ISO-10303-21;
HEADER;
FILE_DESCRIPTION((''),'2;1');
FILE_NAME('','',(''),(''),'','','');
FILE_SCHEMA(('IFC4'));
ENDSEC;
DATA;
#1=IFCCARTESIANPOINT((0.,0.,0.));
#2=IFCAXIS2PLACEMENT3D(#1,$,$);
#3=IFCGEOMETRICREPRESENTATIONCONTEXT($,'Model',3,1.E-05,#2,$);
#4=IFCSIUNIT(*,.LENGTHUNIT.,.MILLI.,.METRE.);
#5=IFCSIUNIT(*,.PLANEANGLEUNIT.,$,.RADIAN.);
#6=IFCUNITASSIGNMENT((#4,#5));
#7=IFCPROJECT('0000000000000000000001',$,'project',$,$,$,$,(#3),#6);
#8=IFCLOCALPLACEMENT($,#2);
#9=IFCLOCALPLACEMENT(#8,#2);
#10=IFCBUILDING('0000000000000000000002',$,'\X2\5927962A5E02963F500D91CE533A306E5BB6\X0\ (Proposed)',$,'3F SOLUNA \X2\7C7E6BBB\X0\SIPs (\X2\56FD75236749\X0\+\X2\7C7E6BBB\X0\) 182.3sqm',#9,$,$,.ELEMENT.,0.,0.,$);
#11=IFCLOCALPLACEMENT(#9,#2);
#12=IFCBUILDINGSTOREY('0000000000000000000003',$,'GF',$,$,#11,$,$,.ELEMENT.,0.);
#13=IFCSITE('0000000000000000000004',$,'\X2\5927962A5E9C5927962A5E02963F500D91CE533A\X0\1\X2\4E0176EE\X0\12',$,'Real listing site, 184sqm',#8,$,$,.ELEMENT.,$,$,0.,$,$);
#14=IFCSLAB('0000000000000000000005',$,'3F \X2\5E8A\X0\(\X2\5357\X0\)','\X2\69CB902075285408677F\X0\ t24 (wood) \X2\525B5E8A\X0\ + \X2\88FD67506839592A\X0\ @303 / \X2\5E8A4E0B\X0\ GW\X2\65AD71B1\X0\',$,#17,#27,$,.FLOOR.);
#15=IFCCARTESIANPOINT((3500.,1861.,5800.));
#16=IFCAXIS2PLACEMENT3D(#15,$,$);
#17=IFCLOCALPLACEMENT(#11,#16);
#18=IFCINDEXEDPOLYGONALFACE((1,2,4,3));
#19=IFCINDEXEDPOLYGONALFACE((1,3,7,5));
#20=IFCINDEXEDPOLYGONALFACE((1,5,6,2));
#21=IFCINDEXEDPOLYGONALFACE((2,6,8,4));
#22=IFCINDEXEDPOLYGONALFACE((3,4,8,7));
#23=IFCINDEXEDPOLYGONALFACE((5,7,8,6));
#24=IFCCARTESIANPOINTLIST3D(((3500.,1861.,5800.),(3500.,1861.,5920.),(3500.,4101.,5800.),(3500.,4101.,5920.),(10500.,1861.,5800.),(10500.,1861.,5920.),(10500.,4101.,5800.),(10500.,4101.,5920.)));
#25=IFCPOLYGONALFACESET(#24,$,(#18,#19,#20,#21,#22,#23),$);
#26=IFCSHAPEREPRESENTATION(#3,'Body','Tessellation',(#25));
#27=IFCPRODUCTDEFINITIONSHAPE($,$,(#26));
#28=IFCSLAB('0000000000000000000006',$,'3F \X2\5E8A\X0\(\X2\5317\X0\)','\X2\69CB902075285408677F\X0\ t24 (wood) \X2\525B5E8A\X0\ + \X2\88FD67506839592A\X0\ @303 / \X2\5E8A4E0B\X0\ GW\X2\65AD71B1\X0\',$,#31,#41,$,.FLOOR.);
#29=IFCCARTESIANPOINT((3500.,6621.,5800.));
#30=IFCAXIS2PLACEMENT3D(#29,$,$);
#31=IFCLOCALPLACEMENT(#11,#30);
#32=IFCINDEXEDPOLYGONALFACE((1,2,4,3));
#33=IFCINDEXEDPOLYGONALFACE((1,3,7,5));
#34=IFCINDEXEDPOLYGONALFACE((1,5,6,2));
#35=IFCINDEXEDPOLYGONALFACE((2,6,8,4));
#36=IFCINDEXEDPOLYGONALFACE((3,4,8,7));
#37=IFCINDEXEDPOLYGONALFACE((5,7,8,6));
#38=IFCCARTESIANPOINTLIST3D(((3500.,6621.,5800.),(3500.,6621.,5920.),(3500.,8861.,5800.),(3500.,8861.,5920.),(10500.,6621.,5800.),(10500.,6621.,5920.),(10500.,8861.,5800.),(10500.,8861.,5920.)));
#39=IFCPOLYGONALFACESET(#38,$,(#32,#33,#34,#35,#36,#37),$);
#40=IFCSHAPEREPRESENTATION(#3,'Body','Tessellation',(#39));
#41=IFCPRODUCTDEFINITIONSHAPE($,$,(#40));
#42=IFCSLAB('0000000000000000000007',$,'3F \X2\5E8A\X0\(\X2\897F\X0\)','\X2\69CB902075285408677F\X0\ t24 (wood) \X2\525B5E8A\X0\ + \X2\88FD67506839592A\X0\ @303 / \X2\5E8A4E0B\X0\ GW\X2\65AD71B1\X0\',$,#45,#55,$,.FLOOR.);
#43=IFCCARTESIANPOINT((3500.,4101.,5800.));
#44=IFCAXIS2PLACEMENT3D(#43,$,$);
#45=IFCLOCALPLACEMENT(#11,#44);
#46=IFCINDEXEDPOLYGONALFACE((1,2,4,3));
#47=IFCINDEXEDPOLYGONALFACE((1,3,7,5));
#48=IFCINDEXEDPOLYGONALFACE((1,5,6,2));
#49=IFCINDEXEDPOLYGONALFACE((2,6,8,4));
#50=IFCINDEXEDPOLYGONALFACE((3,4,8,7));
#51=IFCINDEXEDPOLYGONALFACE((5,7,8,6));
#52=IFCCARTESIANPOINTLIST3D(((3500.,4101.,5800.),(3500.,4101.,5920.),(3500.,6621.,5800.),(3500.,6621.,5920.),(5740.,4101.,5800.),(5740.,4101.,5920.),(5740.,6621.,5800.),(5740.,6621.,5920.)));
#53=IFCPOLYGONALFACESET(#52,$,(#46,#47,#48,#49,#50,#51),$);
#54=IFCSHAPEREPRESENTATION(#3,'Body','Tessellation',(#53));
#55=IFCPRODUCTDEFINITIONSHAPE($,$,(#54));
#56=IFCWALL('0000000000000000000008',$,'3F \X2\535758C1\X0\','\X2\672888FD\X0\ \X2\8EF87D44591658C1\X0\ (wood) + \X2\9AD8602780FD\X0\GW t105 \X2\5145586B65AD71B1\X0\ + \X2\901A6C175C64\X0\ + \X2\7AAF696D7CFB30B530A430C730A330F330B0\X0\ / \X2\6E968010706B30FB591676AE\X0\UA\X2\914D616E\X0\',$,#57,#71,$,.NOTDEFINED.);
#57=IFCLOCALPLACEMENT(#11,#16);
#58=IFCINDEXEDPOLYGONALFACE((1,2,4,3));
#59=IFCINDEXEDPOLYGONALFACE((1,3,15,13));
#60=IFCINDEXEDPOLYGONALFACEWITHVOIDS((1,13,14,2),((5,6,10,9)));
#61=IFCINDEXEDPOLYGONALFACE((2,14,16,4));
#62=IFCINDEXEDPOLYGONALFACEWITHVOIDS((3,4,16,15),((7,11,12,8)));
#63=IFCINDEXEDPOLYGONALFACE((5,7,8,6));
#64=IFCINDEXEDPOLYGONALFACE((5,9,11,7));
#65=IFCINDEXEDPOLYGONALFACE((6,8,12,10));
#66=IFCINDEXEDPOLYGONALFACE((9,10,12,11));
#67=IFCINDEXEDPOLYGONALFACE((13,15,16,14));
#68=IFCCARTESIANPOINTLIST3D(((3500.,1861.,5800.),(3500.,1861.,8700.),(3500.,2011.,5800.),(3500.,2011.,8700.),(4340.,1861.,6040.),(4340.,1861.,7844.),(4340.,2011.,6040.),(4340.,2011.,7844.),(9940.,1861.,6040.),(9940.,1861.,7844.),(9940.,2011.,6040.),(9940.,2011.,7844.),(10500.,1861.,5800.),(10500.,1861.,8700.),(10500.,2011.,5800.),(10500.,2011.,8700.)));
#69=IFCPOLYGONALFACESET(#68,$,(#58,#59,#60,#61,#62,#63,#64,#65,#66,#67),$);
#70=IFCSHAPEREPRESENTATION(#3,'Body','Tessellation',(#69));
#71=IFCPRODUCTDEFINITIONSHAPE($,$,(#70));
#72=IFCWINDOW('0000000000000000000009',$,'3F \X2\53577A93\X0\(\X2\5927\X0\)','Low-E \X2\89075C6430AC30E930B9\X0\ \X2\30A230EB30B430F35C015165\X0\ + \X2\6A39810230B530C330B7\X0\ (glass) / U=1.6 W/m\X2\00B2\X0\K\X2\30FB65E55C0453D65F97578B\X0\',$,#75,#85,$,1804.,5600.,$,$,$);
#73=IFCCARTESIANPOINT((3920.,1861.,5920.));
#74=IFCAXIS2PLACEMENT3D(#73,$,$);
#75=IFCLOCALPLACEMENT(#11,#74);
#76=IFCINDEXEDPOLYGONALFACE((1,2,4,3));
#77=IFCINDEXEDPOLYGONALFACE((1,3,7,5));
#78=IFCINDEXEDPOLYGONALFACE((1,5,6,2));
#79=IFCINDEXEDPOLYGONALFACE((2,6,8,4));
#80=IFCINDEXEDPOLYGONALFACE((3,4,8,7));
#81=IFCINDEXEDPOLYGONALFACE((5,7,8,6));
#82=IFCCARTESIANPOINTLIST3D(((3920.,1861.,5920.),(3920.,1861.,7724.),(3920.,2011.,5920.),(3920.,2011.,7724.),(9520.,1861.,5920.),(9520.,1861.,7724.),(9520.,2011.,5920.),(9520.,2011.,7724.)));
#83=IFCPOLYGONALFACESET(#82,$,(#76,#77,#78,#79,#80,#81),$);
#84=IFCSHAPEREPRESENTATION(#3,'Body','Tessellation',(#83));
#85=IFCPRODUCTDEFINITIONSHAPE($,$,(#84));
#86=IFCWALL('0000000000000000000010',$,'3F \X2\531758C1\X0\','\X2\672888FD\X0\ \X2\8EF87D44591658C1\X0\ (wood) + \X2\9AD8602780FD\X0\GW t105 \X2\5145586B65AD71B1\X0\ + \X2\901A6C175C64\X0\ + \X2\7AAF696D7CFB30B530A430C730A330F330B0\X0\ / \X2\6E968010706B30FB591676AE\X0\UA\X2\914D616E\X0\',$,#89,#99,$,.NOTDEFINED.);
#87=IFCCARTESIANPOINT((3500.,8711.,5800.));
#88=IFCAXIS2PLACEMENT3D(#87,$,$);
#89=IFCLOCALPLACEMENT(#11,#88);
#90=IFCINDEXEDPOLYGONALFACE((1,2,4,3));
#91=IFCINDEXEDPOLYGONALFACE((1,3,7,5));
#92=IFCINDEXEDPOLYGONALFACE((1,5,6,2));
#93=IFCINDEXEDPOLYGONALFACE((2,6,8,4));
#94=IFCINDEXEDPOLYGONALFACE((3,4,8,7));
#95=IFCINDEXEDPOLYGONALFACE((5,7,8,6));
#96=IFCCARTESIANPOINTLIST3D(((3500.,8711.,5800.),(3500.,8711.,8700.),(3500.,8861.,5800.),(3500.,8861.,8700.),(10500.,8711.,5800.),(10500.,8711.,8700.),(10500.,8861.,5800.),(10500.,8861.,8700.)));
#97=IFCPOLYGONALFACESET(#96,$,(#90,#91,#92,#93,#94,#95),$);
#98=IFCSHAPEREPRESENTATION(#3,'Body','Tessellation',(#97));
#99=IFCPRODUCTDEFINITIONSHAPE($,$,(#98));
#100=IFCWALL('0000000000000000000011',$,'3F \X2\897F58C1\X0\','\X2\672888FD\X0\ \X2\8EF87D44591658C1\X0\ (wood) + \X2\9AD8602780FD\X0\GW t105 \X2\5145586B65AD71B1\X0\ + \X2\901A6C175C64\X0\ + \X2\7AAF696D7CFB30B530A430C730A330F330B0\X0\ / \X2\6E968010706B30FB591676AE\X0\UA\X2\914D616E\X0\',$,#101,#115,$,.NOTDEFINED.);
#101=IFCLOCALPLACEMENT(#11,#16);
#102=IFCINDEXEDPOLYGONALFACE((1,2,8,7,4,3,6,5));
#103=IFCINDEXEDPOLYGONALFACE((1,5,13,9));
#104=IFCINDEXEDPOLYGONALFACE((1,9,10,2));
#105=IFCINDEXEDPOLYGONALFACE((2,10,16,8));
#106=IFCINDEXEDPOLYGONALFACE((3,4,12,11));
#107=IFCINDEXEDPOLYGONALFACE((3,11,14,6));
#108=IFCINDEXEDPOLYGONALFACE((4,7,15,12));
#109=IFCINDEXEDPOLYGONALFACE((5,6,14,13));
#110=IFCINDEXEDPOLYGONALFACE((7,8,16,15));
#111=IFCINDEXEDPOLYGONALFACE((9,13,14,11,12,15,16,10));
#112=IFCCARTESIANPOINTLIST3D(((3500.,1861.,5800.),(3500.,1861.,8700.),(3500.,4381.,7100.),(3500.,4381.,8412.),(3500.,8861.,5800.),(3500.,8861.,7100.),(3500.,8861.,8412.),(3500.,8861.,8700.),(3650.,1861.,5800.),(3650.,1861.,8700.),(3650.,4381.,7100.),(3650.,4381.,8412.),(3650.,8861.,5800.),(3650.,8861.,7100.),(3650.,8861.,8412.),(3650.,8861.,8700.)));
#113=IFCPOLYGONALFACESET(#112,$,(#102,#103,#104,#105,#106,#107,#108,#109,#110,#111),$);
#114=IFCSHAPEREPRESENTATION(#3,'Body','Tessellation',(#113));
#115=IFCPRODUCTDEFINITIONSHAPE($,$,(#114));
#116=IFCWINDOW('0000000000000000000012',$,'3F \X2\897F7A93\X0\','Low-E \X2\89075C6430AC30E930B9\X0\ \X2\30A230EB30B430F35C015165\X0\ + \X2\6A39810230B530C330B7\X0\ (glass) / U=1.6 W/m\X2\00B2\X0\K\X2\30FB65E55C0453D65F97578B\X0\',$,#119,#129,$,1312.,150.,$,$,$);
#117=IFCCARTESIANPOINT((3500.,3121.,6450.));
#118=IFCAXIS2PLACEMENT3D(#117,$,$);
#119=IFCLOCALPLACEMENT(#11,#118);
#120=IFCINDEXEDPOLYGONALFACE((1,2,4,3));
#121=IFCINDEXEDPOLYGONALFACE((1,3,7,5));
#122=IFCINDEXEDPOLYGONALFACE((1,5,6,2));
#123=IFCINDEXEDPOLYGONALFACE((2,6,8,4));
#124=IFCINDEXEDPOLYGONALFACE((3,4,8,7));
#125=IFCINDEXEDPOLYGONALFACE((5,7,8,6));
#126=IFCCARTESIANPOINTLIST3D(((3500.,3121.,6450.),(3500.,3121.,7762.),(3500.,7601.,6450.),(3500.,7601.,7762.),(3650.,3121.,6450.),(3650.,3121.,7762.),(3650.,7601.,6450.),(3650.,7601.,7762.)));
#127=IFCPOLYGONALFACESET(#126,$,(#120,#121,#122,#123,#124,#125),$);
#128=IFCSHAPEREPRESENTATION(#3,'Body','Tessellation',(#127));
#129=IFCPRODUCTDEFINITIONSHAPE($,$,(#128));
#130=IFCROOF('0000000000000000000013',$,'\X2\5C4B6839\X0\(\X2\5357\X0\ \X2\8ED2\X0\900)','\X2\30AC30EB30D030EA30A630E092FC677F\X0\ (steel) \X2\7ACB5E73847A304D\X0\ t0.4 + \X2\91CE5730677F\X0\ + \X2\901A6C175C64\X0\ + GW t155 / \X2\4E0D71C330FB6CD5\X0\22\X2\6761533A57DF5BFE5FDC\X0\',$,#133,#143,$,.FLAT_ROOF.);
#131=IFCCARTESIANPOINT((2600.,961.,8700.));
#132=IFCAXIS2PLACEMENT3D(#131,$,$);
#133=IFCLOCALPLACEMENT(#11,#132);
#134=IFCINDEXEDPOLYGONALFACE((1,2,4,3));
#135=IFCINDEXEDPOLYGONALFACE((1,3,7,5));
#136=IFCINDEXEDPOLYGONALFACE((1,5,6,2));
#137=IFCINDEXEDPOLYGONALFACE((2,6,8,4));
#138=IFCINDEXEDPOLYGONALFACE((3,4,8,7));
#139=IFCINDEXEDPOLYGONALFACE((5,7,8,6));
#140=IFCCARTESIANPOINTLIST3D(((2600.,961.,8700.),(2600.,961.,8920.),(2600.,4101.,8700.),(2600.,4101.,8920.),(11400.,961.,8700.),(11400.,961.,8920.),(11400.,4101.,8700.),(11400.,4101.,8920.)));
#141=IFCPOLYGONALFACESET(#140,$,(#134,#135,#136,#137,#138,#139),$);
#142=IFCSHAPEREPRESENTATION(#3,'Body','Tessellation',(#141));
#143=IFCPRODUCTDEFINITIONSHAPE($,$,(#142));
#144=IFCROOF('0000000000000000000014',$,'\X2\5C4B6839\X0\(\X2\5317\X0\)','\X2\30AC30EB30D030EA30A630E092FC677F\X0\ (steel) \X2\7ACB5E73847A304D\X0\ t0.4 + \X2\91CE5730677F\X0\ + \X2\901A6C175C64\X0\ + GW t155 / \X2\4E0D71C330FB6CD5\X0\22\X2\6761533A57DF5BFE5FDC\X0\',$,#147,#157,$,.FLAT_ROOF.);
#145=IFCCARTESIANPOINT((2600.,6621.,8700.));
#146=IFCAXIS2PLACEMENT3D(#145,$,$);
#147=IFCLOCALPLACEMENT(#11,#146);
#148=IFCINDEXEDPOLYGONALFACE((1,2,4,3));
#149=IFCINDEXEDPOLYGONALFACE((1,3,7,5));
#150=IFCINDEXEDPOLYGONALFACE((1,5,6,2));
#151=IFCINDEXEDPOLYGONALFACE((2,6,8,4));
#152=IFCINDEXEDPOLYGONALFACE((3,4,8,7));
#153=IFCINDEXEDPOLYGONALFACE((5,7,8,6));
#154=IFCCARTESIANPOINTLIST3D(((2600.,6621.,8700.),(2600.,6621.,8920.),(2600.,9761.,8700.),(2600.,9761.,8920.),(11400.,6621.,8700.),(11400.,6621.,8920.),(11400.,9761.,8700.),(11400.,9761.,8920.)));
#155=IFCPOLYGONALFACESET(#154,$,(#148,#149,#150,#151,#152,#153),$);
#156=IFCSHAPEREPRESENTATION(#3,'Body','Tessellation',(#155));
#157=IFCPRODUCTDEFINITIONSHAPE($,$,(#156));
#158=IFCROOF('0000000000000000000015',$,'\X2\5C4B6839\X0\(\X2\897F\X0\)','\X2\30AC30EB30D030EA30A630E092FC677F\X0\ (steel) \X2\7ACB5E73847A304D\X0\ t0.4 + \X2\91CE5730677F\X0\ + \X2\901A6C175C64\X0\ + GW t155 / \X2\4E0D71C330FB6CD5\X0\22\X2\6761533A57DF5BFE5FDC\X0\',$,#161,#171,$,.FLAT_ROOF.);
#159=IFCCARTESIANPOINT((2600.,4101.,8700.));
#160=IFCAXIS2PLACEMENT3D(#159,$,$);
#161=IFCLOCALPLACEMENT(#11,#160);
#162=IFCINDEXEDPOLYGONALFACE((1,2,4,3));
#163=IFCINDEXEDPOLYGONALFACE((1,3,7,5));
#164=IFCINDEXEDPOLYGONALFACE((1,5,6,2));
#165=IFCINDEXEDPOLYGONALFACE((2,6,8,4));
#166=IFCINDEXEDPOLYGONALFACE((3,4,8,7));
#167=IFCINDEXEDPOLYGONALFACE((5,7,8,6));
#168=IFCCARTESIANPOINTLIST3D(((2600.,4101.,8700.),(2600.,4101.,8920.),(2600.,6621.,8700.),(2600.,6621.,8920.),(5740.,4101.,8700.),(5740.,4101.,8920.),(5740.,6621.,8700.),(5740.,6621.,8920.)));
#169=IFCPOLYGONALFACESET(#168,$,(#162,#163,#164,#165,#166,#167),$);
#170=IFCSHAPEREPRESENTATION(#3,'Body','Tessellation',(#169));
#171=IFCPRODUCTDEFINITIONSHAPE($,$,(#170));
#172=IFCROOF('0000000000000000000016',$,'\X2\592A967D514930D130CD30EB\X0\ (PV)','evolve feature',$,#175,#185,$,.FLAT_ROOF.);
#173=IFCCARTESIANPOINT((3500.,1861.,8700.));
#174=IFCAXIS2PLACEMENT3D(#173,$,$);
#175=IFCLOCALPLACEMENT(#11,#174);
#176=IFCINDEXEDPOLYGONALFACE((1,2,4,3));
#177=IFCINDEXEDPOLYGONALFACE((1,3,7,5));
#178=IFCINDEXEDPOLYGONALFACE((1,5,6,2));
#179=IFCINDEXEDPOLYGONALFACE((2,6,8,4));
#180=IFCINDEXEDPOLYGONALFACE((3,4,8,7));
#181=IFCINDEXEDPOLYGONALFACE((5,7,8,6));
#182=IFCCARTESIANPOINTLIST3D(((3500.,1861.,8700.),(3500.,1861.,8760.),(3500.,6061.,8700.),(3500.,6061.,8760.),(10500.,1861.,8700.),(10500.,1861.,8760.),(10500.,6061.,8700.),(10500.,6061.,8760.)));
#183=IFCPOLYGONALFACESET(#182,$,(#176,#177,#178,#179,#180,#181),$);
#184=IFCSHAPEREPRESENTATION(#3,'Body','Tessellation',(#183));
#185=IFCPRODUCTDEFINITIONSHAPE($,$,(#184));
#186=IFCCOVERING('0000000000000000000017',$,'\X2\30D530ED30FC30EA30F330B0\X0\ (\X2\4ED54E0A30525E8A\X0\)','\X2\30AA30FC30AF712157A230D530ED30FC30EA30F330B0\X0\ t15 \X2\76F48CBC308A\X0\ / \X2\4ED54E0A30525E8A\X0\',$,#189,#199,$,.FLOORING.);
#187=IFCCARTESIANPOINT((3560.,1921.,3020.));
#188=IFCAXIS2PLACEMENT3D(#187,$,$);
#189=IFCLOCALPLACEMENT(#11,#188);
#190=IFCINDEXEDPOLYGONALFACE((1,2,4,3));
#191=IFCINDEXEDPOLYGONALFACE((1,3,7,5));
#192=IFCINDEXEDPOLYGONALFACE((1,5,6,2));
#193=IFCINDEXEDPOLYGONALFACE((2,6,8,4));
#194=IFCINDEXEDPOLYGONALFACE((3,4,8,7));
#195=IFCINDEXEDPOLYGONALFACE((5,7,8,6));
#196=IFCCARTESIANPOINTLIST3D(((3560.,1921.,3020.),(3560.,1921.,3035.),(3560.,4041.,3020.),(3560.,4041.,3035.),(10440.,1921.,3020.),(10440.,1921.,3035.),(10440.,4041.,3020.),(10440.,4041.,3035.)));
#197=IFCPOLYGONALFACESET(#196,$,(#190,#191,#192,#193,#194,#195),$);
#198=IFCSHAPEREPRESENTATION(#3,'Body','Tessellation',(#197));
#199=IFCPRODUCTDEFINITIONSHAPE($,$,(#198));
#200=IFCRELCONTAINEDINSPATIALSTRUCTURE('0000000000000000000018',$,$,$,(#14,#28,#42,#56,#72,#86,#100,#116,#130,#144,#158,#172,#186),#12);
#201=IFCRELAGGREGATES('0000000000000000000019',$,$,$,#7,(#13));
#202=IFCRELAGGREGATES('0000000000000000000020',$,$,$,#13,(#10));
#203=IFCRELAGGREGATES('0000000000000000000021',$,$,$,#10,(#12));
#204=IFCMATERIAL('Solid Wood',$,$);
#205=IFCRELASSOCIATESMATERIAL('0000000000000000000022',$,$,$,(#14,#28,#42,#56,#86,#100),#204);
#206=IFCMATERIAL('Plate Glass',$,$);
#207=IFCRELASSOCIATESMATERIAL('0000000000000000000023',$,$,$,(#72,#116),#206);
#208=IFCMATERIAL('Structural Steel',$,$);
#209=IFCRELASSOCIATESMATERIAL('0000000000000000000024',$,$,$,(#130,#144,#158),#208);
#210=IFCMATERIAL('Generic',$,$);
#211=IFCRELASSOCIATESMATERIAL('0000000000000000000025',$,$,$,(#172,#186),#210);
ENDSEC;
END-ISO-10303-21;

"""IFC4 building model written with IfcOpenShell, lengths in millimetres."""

from ifc_helpers import new_model, si_unit, frame, frame_2d, origin, place, context, project, spatial, rectangle, extrude, material, element, fill, save


model = new_model("IFC4")

# Units and contexts
model_context = context("Model", 3, precision=1e-05, world=origin())
ifc_project = project(units=[si_unit("LENGTHUNIT", "METRE", prefix="MILLI"), si_unit("PLANEANGLEUNIT", "RADIAN")], contexts=[model_context])

# Site, building, storey
site_placement = place(None, origin())
site = spatial("IfcSite", under=ifc_project, at=site_placement, Name="大阪府大阪市阿倍野区1丁目12", ObjectType="Real listing site, 184sqm", CompositionType="ELEMENT", RefElevation=0.0)
building_placement = place(site_placement, origin())
building = spatial("IfcBuilding", under=site, at=building_placement, Name="大阪市阿倍野区の家 (Proposed)", ObjectType="3F SOLUNA 籾殻SIPs (国産杉+籾殻) 182.3sqm", CompositionType="ELEMENT", ElevationOfRefHeight=0.0, ElevationOfTerrain=0.0)
storey_placement = place(building_placement, origin())
storey = spatial("IfcBuildingStorey", under=building, at=storey_placement, Name="GF", CompositionType="ELEMENT", Elevation=0.0)

# Slabs
ifc_material_1 = material(Name="Solid Wood")
slab_1_placement = place(storey_placement, frame((3500.0, 1861.0, 5800.0)))
element("IfcSlab", 1, at=slab_1_placement, inside=storey, material=ifc_material_1, Name="3F 床(南)", Description="構造用合板 t24 (wood) 剛床 + 製材根太 @303 / 床下 GW断熱", PredefinedType="FLOOR", context=model_context, shape_type="SweptSolid", body=[
    extrude(rectangle(XDim=7000.0, YDim=2240.0, at=frame_2d((3500.0, 1120.0))), frame((3500.0, 1861.0, 5800.0)), (0.0, 0.0, 1.0), 120.0),
])
slab_2_placement = place(storey_placement, frame((3500.0, 6621.0, 5800.0)))
element("IfcSlab", 2, at=slab_2_placement, inside=storey, material=ifc_material_1, Name="3F 床(北)", Description="構造用合板 t24 (wood) 剛床 + 製材根太 @303 / 床下 GW断熱", PredefinedType="FLOOR", context=model_context, shape_type="SweptSolid", body=[
    extrude(rectangle(XDim=7000.0, YDim=2240.0, at=frame_2d((3500.0, 1120.0))), frame((3500.0, 6621.0, 5800.0)), (0.0, 0.0, 1.0), 120.0),
])
slab_3_placement = place(storey_placement, frame((3500.0, 4101.0, 5800.0)))
element("IfcSlab", 3, at=slab_3_placement, inside=storey, material=ifc_material_1, Name="3F 床(西)", Description="構造用合板 t24 (wood) 剛床 + 製材根太 @303 / 床下 GW断熱", PredefinedType="FLOOR", context=model_context, shape_type="SweptSolid", body=[
    extrude(rectangle(XDim=2240.0, YDim=2520.0, at=frame_2d((1120.0, 1260.0))), frame((3500.0, 4101.0, 5800.0)), (0.0, 0.0, 1.0), 120.0),
])

# Wall, opening, window
wall_1_placement = place(storey_placement, frame((3500.0, 1861.0, 5800.0)))
wall_1 = element("IfcWall", 4, at=wall_1_placement, inside=storey, material=ifc_material_1, Name="3F 南壁", Description="木製 軸組外壁 (wood) + 高性能GW t105 充填断熱 + 通気層 + 窯業系サイディング / 準耐火・外皮UA配慮", PredefinedType="NOTDEFINED", context=model_context, shape_type="SweptSolid", body=[
    extrude(rectangle(XDim=7000.0, YDim=150.0, at=frame_2d((3500.0, 75.0))), frame((3500.0, 1861.0, 5800.0)), (0.0, 0.0, 1.0), 2900.0),
])
opening_1_placement = place(storey_placement, frame((3920.0, 1861.0, 5920.0)))
opening_1 = element("IfcOpeningElement", 5, at=opening_1_placement, cuts=wall_1, PredefinedType="NOTDEFINED", context=model_context, shape_type="SweptSolid", body=[
    extrude(rectangle(XDim=5600.0, YDim=150.0, at=frame_2d((2800.0, 75.0))), frame((3920.0, 1861.0, 5920.0)), (0.0, 0.0, 1.0), 1804.0),
])
ifc_material_2 = material(Name="Plate Glass")
window_1_placement = place(storey_placement, frame((3920.0, 1861.0, 5920.0)))
window_1 = element("IfcWindow", 6, at=window_1_placement, inside=storey, material=ifc_material_2, Name="3F 南窓(大)", Description="Low-E 複層ガラス アルゴン封入 + 樹脂サッシ (glass) / U=1.6 W/m²K・日射取得型", OverallHeight=1804.0, OverallWidth=5600.0, context=model_context, shape_type="SweptSolid", body=[
    extrude(rectangle(XDim=5600.0, YDim=150.0, at=frame_2d((2800.0, 75.0))), frame((3920.0, 1861.0, 5920.0)), (0.0, 0.0, 1.0), 1804.0),
])
fill(opening_1, window_1)

# Wall
wall_2_placement = place(storey_placement, frame((3500.0, 8711.0, 5800.0)))
element("IfcWall", 7, at=wall_2_placement, inside=storey, material=ifc_material_1, Name="3F 北壁", Description="木製 軸組外壁 (wood) + 高性能GW t105 充填断熱 + 通気層 + 窯業系サイディング / 準耐火・外皮UA配慮", PredefinedType="NOTDEFINED", context=model_context, shape_type="SweptSolid", body=[
    extrude(rectangle(XDim=7000.0, YDim=150.0, at=frame_2d((3500.0, 75.0))), frame((3500.0, 8711.0, 5800.0)), (0.0, 0.0, 1.0), 2900.0),
])

# Wall, opening, window
wall_3_placement = place(storey_placement, frame((3500.0, 1861.0, 5800.0)))
wall_3 = element("IfcWall", 8, at=wall_3_placement, inside=storey, material=ifc_material_1, Name="3F 西壁", Description="木製 軸組外壁 (wood) + 高性能GW t105 充填断熱 + 通気層 + 窯業系サイディング / 準耐火・外皮UA配慮", PredefinedType="NOTDEFINED", context=model_context, shape_type="SweptSolid", body=[
    extrude(rectangle(XDim=150.0, YDim=7000.0, at=frame_2d((75.0, 3500.0))), frame((3500.0, 1861.0, 5800.0)), (0.0, 0.0, 1.0), 2900.0),
])
opening_2_placement = place(storey_placement, frame((3500.0, 3121.0, 6450.0)))
opening_2 = element("IfcOpeningElement", 9, at=opening_2_placement, cuts=wall_3, PredefinedType="NOTDEFINED", context=model_context, shape_type="SweptSolid", body=[
    extrude(rectangle(XDim=150.0, YDim=4480.0, at=frame_2d((75.0, 2240.0))), frame((3500.0, 3121.0, 6450.0)), (0.0, 0.0, 1.0), 1312.0),
])
window_2_placement = place(storey_placement, frame((3500.0, 3121.0, 6450.0)))
window_2 = element("IfcWindow", 10, at=window_2_placement, inside=storey, material=ifc_material_2, Name="3F 西窓", Description="Low-E 複層ガラス アルゴン封入 + 樹脂サッシ (glass) / U=1.6 W/m²K・日射取得型", OverallHeight=1312.0, OverallWidth=150.0, context=model_context, shape_type="SweptSolid", body=[
    extrude(rectangle(XDim=150.0, YDim=4480.0, at=frame_2d((75.0, 2240.0))), frame((3500.0, 3121.0, 6450.0)), (0.0, 0.0, 1.0), 1312.0),
])
fill(opening_2, window_2)

# Roofs
ifc_material_3 = material(Name="Structural Steel")
roof_1_placement = place(storey_placement, frame((2600.0, 961.0, 8700.0)))
element("IfcRoof", 11, at=roof_1_placement, inside=storey, material=ifc_material_3, Name="屋根(南 軒900)", Description="ガルバリウム鋼板 (steel) 立平葺き t0.4 + 野地板 + 通気層 + GW t155 / 不燃・法22条区域対応", PredefinedType="FLAT_ROOF", context=model_context, shape_type="SweptSolid", body=[
    extrude(rectangle(XDim=8800.0, YDim=3140.0, at=frame_2d((4400.0, 1570.0))), frame((2600.0, 961.0, 8700.0)), (0.0, 0.0, 1.0), 220.0),
])
roof_2_placement = place(storey_placement, frame((2600.0, 6621.0, 8700.0)))
element("IfcRoof", 12, at=roof_2_placement, inside=storey, material=ifc_material_3, Name="屋根(北)", Description="ガルバリウム鋼板 (steel) 立平葺き t0.4 + 野地板 + 通気層 + GW t155 / 不燃・法22条区域対応", PredefinedType="FLAT_ROOF", context=model_context, shape_type="SweptSolid", body=[
    extrude(rectangle(XDim=8800.0, YDim=3140.0, at=frame_2d((4400.0, 1570.0))), frame((2600.0, 6621.0, 8700.0)), (0.0, 0.0, 1.0), 220.0),
])
roof_3_placement = place(storey_placement, frame((2600.0, 4101.0, 8700.0)))
element("IfcRoof", 13, at=roof_3_placement, inside=storey, material=ifc_material_3, Name="屋根(西)", Description="ガルバリウム鋼板 (steel) 立平葺き t0.4 + 野地板 + 通気層 + GW t155 / 不燃・法22条区域対応", PredefinedType="FLAT_ROOF", context=model_context, shape_type="SweptSolid", body=[
    extrude(rectangle(XDim=3140.0, YDim=2520.0, at=frame_2d((1570.0, 1260.0))), frame((2600.0, 4101.0, 8700.0)), (0.0, 0.0, 1.0), 220.0),
])
ifc_material_4 = material(Name="Generic")
roof_4_placement = place(storey_placement, frame((3500.0, 1861.0, 8700.0)))
element("IfcRoof", 14, at=roof_4_placement, inside=storey, material=ifc_material_4, Name="太陽光パネル (PV)", Description="evolve feature", PredefinedType="FLAT_ROOF", context=model_context, shape_type="SweptSolid", body=[
    extrude(rectangle(XDim=7000.0, YDim=4200.0, at=frame_2d((3500.0, 2100.0))), frame((3500.0, 1861.0, 8700.0)), (0.0, 0.0, 1.0), 60.0),
])

# Covering
covering_1_placement = place(storey_placement, frame((3560.0, 1921.0, 3020.0)))
element("IfcCovering", 15, at=covering_1_placement, inside=storey, material=ifc_material_4, Name="フローリング (仕上げ床)", Description="オーク無垢フローリング t15 直貼り / 仕上げ床", PredefinedType="FLOORING", context=model_context, shape_type="SweptSolid", body=[
    extrude(rectangle(XDim=6880.0, YDim=2120.0, at=frame_2d((3440.0, 1060.0))), frame((3560.0, 1921.0, 3020.0)), (0.0, 0.0, 1.0), 15.0),
])

save(model, "model.ifc")
